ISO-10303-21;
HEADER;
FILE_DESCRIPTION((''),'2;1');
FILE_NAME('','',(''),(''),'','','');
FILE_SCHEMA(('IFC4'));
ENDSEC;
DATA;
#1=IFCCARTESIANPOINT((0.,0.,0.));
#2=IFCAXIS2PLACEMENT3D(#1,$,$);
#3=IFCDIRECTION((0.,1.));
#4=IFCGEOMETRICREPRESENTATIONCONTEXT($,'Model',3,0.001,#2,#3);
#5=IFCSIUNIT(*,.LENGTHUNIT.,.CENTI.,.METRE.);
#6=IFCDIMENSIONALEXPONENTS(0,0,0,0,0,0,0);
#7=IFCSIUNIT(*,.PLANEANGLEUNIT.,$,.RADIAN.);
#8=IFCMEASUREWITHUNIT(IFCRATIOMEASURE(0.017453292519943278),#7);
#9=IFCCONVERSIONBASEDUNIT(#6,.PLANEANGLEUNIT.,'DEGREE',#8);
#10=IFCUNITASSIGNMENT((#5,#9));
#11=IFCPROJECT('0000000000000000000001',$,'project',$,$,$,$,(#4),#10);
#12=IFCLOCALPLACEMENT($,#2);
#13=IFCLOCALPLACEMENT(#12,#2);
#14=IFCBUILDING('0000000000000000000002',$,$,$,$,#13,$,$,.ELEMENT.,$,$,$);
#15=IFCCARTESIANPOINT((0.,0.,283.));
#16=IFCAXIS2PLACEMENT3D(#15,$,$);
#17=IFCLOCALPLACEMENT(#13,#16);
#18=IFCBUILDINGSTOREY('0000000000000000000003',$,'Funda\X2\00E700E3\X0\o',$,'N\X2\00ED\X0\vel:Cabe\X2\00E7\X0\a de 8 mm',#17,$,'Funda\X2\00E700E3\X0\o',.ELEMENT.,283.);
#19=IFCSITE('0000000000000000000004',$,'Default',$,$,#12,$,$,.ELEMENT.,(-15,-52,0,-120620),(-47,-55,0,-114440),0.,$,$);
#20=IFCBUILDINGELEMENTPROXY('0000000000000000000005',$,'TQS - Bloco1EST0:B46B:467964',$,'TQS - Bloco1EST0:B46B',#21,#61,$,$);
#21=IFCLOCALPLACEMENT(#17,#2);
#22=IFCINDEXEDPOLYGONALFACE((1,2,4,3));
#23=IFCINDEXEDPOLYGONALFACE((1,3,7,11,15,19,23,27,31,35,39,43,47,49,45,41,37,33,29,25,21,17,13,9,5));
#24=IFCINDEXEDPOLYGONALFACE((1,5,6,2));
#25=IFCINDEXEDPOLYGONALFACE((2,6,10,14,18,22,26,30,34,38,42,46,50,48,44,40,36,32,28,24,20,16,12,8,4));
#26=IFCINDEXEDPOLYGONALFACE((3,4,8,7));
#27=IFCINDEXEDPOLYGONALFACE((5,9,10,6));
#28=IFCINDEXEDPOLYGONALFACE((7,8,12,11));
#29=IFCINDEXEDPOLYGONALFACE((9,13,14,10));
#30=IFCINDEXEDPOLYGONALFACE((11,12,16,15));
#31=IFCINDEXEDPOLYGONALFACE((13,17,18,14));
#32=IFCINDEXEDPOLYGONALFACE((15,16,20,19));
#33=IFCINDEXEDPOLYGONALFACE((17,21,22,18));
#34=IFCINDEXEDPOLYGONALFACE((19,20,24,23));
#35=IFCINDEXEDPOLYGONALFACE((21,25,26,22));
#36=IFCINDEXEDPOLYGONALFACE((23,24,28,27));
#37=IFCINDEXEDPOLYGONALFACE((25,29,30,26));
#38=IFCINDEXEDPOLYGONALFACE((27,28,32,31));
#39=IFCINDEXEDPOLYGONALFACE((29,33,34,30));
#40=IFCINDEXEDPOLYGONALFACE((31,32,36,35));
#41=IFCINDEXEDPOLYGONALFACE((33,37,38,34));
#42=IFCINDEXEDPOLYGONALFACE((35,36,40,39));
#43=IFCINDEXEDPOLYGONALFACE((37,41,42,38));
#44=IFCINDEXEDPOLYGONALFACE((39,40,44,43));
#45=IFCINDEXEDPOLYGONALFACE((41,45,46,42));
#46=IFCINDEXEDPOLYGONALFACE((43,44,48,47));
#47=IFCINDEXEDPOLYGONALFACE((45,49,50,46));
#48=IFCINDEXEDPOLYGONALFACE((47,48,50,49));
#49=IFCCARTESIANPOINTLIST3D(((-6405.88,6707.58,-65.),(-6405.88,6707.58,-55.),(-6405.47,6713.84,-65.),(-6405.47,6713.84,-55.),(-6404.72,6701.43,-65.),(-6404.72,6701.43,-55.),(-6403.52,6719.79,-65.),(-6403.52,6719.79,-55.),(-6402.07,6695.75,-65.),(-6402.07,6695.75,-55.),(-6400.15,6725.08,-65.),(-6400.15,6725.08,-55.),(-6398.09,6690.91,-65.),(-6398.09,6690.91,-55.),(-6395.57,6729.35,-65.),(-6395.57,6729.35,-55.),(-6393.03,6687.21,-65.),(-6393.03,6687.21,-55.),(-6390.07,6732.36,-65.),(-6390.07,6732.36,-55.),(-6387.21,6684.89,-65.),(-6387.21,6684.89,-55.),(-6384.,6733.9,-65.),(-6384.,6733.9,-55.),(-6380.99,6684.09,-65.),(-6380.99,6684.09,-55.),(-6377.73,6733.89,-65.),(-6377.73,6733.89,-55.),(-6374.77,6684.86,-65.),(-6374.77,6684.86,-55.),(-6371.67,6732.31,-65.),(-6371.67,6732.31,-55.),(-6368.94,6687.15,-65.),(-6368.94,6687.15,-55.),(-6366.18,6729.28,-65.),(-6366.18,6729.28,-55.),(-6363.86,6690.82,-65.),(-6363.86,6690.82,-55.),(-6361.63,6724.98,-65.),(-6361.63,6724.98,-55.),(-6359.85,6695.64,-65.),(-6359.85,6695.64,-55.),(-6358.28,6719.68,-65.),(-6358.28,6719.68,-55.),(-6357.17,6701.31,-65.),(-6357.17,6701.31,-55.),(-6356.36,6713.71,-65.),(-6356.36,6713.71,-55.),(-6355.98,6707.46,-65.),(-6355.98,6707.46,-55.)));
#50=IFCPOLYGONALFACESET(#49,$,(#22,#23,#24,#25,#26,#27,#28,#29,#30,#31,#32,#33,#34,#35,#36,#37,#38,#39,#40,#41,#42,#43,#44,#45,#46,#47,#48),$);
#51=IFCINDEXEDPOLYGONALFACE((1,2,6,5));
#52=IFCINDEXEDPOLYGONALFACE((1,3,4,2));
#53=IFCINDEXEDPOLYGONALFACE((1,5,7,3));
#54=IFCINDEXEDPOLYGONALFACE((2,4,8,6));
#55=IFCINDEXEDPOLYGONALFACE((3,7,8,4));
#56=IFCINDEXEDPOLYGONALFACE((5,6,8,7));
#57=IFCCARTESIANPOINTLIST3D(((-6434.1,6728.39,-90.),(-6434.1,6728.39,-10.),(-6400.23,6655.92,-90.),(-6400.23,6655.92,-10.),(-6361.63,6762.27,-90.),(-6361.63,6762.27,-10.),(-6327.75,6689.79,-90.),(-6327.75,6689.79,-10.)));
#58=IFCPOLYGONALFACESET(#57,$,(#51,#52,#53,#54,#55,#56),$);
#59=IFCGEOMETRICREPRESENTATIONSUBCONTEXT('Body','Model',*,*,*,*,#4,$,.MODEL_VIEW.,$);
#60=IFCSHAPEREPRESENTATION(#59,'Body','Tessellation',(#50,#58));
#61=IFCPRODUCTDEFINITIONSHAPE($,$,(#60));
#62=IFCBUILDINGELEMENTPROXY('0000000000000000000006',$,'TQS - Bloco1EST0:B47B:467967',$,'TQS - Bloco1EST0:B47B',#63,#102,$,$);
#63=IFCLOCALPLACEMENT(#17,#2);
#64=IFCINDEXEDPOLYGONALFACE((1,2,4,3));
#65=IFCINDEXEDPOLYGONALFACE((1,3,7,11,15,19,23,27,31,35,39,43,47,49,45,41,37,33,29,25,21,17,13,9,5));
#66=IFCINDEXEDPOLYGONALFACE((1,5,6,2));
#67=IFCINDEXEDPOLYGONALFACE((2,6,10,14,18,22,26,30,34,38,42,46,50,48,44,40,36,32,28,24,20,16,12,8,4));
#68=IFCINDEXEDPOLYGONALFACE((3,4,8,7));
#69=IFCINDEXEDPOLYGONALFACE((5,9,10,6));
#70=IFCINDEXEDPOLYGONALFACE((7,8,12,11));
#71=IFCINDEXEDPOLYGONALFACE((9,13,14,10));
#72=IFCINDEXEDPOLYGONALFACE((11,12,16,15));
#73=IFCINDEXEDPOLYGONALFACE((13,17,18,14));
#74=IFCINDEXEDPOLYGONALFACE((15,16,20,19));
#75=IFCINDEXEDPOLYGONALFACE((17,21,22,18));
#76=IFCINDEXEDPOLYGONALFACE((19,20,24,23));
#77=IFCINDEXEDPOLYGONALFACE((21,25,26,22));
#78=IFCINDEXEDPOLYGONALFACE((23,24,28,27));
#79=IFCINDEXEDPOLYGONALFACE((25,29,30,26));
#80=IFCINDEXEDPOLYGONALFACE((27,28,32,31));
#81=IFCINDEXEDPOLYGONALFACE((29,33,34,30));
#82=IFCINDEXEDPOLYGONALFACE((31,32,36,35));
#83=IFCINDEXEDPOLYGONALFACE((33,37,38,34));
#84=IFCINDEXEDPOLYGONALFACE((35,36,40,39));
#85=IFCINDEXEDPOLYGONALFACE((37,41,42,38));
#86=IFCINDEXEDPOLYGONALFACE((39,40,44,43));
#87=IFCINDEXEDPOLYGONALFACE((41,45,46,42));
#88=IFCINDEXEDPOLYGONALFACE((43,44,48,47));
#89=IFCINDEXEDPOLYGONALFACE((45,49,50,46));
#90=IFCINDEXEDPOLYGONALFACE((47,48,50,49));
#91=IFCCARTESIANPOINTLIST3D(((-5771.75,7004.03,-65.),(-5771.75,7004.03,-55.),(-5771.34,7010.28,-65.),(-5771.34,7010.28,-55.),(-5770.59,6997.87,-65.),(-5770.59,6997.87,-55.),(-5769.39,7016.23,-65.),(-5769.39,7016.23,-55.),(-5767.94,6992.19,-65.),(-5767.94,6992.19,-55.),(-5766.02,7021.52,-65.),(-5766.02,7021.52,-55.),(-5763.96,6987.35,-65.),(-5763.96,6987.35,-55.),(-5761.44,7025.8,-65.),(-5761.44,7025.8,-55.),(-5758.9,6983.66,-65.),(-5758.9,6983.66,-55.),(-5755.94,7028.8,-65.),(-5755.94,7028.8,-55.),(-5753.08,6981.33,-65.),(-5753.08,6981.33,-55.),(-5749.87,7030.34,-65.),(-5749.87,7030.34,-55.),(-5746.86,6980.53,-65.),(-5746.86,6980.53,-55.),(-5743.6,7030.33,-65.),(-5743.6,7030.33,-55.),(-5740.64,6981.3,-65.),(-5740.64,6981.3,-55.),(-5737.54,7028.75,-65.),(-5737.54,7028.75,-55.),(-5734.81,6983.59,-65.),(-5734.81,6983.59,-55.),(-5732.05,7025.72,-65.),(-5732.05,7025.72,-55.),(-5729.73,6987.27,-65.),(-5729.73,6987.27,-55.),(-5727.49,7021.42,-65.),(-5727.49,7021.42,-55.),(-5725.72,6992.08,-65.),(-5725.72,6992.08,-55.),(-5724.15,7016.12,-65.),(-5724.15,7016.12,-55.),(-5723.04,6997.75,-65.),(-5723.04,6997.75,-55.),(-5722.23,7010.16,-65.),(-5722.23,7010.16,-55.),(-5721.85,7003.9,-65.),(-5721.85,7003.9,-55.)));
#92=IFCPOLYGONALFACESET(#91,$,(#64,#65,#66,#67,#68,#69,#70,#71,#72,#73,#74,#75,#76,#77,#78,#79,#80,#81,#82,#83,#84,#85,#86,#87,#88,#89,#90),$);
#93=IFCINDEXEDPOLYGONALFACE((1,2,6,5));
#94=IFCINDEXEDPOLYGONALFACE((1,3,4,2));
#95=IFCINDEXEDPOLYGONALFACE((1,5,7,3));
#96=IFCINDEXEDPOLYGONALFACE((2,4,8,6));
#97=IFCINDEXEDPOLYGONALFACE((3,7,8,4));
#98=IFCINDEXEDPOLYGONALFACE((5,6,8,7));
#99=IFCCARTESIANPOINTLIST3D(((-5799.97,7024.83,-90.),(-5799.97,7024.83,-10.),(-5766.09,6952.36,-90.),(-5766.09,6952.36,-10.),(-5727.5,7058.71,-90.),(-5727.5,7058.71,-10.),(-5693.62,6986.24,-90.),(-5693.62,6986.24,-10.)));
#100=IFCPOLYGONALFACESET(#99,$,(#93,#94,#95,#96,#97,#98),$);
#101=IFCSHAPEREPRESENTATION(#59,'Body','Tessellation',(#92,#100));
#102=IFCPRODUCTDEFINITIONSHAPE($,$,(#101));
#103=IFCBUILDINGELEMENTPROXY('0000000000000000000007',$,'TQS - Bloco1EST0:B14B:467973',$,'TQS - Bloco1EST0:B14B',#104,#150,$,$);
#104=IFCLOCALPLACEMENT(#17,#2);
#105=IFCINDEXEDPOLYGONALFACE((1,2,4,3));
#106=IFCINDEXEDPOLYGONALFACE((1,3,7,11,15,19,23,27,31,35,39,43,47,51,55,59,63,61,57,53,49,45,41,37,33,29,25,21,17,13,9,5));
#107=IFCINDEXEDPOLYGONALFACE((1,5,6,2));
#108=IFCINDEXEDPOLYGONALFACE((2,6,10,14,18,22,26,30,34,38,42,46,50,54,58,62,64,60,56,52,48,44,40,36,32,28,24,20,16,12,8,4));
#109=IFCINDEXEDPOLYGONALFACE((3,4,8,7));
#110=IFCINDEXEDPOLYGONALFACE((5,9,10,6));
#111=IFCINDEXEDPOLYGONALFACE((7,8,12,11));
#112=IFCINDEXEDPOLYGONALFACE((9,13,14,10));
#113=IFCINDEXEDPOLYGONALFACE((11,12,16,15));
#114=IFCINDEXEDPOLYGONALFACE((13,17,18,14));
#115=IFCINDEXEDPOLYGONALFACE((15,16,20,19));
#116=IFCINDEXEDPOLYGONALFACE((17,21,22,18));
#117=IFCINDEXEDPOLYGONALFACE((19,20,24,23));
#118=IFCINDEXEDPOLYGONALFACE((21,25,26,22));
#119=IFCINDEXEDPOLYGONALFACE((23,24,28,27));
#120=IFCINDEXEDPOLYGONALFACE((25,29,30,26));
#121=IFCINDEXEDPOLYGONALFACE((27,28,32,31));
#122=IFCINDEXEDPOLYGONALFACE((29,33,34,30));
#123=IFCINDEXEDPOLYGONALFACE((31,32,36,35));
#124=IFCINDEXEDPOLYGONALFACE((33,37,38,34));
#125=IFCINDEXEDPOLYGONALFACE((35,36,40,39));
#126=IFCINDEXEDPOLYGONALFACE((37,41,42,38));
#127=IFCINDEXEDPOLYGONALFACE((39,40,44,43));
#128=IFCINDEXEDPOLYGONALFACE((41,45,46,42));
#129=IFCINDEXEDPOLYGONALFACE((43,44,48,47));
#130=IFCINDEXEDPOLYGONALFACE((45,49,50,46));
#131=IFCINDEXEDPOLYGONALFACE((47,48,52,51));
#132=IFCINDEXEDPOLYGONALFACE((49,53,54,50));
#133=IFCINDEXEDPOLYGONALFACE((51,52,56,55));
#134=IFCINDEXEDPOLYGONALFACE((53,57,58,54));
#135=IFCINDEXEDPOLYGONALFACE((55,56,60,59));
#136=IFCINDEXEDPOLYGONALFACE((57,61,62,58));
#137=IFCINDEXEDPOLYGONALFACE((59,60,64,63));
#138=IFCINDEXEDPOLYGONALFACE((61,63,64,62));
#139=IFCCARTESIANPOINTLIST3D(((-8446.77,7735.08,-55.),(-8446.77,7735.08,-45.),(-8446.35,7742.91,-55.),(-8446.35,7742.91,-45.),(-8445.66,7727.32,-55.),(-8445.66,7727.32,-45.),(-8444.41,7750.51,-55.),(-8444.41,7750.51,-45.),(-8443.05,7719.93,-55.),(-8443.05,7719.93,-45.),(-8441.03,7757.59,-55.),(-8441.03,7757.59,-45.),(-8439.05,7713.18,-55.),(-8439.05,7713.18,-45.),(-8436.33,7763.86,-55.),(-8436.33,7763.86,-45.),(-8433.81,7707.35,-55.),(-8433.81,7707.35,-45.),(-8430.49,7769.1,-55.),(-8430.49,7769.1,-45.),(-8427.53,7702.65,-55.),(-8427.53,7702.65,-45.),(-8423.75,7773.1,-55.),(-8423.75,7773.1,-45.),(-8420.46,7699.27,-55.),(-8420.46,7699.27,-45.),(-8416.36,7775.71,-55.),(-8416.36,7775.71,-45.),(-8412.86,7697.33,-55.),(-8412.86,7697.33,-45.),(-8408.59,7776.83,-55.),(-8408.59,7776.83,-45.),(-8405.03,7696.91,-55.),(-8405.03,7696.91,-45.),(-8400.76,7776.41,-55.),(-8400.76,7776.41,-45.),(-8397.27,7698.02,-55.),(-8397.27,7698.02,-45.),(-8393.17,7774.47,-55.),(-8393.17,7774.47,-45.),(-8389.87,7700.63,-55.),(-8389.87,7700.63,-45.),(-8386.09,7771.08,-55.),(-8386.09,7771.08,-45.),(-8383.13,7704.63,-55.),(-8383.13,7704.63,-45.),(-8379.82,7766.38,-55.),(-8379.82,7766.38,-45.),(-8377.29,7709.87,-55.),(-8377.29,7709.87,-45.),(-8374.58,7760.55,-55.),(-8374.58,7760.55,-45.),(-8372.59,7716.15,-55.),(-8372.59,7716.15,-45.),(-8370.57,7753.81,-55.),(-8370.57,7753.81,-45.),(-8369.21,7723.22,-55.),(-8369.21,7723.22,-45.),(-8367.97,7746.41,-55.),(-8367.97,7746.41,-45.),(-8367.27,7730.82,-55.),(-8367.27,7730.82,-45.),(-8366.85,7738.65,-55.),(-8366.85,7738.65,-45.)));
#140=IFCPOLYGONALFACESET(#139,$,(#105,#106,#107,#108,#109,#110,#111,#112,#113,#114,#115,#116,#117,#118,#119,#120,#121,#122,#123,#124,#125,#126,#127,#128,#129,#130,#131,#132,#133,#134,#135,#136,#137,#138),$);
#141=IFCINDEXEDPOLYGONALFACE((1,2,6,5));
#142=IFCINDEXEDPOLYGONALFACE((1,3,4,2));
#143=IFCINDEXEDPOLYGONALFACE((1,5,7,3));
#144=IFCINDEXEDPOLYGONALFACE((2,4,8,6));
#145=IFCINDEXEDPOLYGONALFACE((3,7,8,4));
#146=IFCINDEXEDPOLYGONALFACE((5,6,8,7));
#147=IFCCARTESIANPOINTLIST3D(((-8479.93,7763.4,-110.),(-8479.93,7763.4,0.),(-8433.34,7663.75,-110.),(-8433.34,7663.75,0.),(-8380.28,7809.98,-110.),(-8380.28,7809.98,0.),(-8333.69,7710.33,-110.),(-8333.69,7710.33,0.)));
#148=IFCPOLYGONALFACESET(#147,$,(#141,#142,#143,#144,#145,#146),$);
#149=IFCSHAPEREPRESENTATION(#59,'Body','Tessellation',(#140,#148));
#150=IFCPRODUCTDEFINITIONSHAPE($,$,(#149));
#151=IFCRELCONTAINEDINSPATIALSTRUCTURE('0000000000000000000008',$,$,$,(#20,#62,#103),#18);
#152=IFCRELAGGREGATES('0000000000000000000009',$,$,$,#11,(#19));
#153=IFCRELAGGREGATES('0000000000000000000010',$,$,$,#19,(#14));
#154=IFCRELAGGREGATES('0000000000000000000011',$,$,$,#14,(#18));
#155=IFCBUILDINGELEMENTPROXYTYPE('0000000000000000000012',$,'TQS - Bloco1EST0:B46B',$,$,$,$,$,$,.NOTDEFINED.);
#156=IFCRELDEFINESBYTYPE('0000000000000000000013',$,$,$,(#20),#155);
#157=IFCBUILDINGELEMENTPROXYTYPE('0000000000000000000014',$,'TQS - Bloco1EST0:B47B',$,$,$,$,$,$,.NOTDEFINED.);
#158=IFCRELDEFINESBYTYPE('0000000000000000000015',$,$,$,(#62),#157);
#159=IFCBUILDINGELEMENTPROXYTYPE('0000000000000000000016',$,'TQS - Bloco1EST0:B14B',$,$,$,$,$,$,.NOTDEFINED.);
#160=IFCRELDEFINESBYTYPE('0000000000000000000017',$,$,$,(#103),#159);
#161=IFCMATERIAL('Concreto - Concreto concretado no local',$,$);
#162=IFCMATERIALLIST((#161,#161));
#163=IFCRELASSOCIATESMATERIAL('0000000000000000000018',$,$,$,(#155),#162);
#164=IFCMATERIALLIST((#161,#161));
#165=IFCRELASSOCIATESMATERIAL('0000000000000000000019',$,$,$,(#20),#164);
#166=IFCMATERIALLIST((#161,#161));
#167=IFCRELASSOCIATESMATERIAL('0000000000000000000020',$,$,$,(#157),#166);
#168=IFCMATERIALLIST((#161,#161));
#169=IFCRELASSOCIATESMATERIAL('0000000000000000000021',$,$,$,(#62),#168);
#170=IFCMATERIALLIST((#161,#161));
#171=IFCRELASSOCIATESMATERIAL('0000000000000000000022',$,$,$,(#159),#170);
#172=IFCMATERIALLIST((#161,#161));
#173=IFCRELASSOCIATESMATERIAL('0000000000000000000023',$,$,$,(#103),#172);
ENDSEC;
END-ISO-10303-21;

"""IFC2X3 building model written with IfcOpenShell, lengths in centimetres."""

from ifc_helpers import new_model, entity, si_unit, converted_unit, direction, frame, frame_2d, origin, origin_2d_with_axis, place, context, subcontext, project, spatial, rectangle, circle, extrude, source, transform, mapped, material, material_list, type_object, type_shapes, element, save


model = new_model("IFC2X3")

# Units and contexts
model_context = context("Model", 3, precision=0.001, world=origin(), true_north=direction((0.0, 1.0)))
body_context = subcontext(model_context, "Body", "Model", "MODEL_VIEW")
ifc_project = project(units=[si_unit("LENGTHUNIT", "METRE", prefix="CENTI"), converted_unit("PLANEANGLEUNIT", "DEGREE", entity("IfcRatioMeasure", 0.017453292519943278), si_unit("PLANEANGLEUNIT", "RADIAN"), dimensions=[0, 0, 0, 0, 0, 0, 0])], contexts=[model_context])

# Site, building, storey
site_placement = place(None, origin())
site = spatial("IfcSite", under=ifc_project, at=site_placement, Name="Default", CompositionType="ELEMENT", RefLatitude=(-15, -52, 0, -120620), RefLongitude=(-47, -55, 0, -114440), RefElevation=0.0)
building_placement = place(site_placement, origin())
building = spatial("IfcBuilding", under=site, at=building_placement, CompositionType="ELEMENT")
storey_placement = place(building_placement, frame((0.0, 0.0, 283.0)))
storey = spatial("IfcBuildingStorey", under=building, at=storey_placement, Name="Fundação", ObjectType="Nível:Cabeça de 8 mm", LongName="Fundação", CompositionType="ELEMENT", Elevation=283.0)

# Building element proxies
ifc_material_1 = material(Name="Concreto - Concreto concretado no local")
ifc_material_list_1 = material_list([ifc_material_1, ifc_material_1])
ifc_material_list_2 = material_list([ifc_material_1, ifc_material_1])
building_element_proxy_type_1 = type_object("IfcBuildingElementProxyType", Name="TQS - Bloco1EST0:B46B", PredefinedType="NOTDEFINED", material=ifc_material_list_2)
shared_shape_1 = source(origin(), body_context, "Body", "SweptSolid", [
    extrude(circle(Radius=25.0, at=frame_2d((0.0, 0.0), x_axis=(1.0, 0.0))), frame((0.0, 0.0, -55.0)), (0.0, 0.0, 1.0), 10.0),
    extrude(rectangle(XDim=80.0, YDim=80.0, at=origin_2d_with_axis()), frame((0.0, 0.0, -80.0), z_axis=(0.0, 0.0, 1.0), x_axis=(-1.0, 0.0, 0.0)), (0.0, 0.0, 1.0), 80.0),
])
type_shapes(building_element_proxy_type_1, [shared_shape_1])
proxy_1_placement = place(storey_placement, frame((-6380.93, 6709.09, -10.0), z_axis=(0.0, 0.0, 1.0), x_axis=(0.905902, 0.423488, 0.0)))
element("IfcBuildingElementProxy", 1, at=proxy_1_placement, inside=storey, type_object=building_element_proxy_type_1, material=ifc_material_list_1, Name="TQS - Bloco1EST0:B46B:467964", ObjectType="TQS - Bloco1EST0:B46B", context=body_context, shape_type="MappedRepresentation", body=[
    mapped(shared_shape_1, transform((0.0, 0.0, 0.0), scale=1.0)),
])
ifc_material_list_3 = material_list([ifc_material_1, ifc_material_1])
ifc_material_list_4 = material_list([ifc_material_1, ifc_material_1])
building_element_proxy_type_2 = type_object("IfcBuildingElementProxyType", Name="TQS - Bloco1EST0:B47B", PredefinedType="NOTDEFINED", material=ifc_material_list_4)
shared_shape_2 = source(origin(), body_context, "Body", "SweptSolid", [
    extrude(circle(Radius=25.0, at=frame_2d((0.0, 0.0), x_axis=(1.0, 0.0))), frame((0.0, 0.0, -55.0)), (0.0, 0.0, 1.0), 10.0),
    extrude(rectangle(XDim=80.0, YDim=80.0, at=origin_2d_with_axis()), frame((0.0, 0.0, -80.0), z_axis=(0.0, 0.0, 1.0), x_axis=(-1.0, 0.0, 0.0)), (0.0, 0.0, 1.0), 80.0),
])
type_shapes(building_element_proxy_type_2, [shared_shape_2])
proxy_2_placement = place(storey_placement, frame((-5746.8, 7005.53, -10.0), z_axis=(0.0, 0.0, 1.0), x_axis=(0.905902, 0.423488, 0.0)))
element("IfcBuildingElementProxy", 2, at=proxy_2_placement, inside=storey, type_object=building_element_proxy_type_2, material=ifc_material_list_3, Name="TQS - Bloco1EST0:B47B:467967", ObjectType="TQS - Bloco1EST0:B47B", context=body_context, shape_type="MappedRepresentation", body=[
    mapped(shared_shape_2, transform((0.0, 0.0, 0.0), scale=1.0)),
])
ifc_material_list_5 = material_list([ifc_material_1, ifc_material_1])
ifc_material_list_6 = material_list([ifc_material_1, ifc_material_1])
building_element_proxy_type_3 = type_object("IfcBuildingElementProxyType", Name="TQS - Bloco1EST0:B14B", PredefinedType="NOTDEFINED", material=ifc_material_list_6)
shared_shape_3 = source(origin(), body_context, "Body", "SweptSolid", [
    extrude(circle(Radius=40.0, at=frame_2d((0.0, 0.0), x_axis=(1.0, 0.0))), frame((0.0, 0.0, -55.0)), (0.0, 0.0, 1.0), 10.0),
    extrude(rectangle(XDim=110.0, YDim=110.0, at=origin_2d_with_axis()), frame((0.0, 0.0, -110.0), z_axis=(0.0, 0.0, 1.0), x_axis=(-1.0, 0.0, 0.0)), (0.0, 0.0, 1.0), 110.0),
])
type_shapes(building_element_proxy_type_3, [shared_shape_3])
proxy_3_placement = place(storey_placement, frame((-8406.81, 7736.87, 0.0), z_axis=(0.0, 0.0, 1.0), x_axis=(0.905902, 0.423488, 0.0)))
element("IfcBuildingElementProxy", 3, at=proxy_3_placement, inside=storey, type_object=building_element_proxy_type_3, material=ifc_material_list_5, Name="TQS - Bloco1EST0:B14B:467973", ObjectType="TQS - Bloco1EST0:B14B", context=body_context, shape_type="MappedRepresentation", body=[
    mapped(shared_shape_3, transform((0.0, 0.0, 0.0), scale=1.0)),
])

save(model, "model.ifc")
